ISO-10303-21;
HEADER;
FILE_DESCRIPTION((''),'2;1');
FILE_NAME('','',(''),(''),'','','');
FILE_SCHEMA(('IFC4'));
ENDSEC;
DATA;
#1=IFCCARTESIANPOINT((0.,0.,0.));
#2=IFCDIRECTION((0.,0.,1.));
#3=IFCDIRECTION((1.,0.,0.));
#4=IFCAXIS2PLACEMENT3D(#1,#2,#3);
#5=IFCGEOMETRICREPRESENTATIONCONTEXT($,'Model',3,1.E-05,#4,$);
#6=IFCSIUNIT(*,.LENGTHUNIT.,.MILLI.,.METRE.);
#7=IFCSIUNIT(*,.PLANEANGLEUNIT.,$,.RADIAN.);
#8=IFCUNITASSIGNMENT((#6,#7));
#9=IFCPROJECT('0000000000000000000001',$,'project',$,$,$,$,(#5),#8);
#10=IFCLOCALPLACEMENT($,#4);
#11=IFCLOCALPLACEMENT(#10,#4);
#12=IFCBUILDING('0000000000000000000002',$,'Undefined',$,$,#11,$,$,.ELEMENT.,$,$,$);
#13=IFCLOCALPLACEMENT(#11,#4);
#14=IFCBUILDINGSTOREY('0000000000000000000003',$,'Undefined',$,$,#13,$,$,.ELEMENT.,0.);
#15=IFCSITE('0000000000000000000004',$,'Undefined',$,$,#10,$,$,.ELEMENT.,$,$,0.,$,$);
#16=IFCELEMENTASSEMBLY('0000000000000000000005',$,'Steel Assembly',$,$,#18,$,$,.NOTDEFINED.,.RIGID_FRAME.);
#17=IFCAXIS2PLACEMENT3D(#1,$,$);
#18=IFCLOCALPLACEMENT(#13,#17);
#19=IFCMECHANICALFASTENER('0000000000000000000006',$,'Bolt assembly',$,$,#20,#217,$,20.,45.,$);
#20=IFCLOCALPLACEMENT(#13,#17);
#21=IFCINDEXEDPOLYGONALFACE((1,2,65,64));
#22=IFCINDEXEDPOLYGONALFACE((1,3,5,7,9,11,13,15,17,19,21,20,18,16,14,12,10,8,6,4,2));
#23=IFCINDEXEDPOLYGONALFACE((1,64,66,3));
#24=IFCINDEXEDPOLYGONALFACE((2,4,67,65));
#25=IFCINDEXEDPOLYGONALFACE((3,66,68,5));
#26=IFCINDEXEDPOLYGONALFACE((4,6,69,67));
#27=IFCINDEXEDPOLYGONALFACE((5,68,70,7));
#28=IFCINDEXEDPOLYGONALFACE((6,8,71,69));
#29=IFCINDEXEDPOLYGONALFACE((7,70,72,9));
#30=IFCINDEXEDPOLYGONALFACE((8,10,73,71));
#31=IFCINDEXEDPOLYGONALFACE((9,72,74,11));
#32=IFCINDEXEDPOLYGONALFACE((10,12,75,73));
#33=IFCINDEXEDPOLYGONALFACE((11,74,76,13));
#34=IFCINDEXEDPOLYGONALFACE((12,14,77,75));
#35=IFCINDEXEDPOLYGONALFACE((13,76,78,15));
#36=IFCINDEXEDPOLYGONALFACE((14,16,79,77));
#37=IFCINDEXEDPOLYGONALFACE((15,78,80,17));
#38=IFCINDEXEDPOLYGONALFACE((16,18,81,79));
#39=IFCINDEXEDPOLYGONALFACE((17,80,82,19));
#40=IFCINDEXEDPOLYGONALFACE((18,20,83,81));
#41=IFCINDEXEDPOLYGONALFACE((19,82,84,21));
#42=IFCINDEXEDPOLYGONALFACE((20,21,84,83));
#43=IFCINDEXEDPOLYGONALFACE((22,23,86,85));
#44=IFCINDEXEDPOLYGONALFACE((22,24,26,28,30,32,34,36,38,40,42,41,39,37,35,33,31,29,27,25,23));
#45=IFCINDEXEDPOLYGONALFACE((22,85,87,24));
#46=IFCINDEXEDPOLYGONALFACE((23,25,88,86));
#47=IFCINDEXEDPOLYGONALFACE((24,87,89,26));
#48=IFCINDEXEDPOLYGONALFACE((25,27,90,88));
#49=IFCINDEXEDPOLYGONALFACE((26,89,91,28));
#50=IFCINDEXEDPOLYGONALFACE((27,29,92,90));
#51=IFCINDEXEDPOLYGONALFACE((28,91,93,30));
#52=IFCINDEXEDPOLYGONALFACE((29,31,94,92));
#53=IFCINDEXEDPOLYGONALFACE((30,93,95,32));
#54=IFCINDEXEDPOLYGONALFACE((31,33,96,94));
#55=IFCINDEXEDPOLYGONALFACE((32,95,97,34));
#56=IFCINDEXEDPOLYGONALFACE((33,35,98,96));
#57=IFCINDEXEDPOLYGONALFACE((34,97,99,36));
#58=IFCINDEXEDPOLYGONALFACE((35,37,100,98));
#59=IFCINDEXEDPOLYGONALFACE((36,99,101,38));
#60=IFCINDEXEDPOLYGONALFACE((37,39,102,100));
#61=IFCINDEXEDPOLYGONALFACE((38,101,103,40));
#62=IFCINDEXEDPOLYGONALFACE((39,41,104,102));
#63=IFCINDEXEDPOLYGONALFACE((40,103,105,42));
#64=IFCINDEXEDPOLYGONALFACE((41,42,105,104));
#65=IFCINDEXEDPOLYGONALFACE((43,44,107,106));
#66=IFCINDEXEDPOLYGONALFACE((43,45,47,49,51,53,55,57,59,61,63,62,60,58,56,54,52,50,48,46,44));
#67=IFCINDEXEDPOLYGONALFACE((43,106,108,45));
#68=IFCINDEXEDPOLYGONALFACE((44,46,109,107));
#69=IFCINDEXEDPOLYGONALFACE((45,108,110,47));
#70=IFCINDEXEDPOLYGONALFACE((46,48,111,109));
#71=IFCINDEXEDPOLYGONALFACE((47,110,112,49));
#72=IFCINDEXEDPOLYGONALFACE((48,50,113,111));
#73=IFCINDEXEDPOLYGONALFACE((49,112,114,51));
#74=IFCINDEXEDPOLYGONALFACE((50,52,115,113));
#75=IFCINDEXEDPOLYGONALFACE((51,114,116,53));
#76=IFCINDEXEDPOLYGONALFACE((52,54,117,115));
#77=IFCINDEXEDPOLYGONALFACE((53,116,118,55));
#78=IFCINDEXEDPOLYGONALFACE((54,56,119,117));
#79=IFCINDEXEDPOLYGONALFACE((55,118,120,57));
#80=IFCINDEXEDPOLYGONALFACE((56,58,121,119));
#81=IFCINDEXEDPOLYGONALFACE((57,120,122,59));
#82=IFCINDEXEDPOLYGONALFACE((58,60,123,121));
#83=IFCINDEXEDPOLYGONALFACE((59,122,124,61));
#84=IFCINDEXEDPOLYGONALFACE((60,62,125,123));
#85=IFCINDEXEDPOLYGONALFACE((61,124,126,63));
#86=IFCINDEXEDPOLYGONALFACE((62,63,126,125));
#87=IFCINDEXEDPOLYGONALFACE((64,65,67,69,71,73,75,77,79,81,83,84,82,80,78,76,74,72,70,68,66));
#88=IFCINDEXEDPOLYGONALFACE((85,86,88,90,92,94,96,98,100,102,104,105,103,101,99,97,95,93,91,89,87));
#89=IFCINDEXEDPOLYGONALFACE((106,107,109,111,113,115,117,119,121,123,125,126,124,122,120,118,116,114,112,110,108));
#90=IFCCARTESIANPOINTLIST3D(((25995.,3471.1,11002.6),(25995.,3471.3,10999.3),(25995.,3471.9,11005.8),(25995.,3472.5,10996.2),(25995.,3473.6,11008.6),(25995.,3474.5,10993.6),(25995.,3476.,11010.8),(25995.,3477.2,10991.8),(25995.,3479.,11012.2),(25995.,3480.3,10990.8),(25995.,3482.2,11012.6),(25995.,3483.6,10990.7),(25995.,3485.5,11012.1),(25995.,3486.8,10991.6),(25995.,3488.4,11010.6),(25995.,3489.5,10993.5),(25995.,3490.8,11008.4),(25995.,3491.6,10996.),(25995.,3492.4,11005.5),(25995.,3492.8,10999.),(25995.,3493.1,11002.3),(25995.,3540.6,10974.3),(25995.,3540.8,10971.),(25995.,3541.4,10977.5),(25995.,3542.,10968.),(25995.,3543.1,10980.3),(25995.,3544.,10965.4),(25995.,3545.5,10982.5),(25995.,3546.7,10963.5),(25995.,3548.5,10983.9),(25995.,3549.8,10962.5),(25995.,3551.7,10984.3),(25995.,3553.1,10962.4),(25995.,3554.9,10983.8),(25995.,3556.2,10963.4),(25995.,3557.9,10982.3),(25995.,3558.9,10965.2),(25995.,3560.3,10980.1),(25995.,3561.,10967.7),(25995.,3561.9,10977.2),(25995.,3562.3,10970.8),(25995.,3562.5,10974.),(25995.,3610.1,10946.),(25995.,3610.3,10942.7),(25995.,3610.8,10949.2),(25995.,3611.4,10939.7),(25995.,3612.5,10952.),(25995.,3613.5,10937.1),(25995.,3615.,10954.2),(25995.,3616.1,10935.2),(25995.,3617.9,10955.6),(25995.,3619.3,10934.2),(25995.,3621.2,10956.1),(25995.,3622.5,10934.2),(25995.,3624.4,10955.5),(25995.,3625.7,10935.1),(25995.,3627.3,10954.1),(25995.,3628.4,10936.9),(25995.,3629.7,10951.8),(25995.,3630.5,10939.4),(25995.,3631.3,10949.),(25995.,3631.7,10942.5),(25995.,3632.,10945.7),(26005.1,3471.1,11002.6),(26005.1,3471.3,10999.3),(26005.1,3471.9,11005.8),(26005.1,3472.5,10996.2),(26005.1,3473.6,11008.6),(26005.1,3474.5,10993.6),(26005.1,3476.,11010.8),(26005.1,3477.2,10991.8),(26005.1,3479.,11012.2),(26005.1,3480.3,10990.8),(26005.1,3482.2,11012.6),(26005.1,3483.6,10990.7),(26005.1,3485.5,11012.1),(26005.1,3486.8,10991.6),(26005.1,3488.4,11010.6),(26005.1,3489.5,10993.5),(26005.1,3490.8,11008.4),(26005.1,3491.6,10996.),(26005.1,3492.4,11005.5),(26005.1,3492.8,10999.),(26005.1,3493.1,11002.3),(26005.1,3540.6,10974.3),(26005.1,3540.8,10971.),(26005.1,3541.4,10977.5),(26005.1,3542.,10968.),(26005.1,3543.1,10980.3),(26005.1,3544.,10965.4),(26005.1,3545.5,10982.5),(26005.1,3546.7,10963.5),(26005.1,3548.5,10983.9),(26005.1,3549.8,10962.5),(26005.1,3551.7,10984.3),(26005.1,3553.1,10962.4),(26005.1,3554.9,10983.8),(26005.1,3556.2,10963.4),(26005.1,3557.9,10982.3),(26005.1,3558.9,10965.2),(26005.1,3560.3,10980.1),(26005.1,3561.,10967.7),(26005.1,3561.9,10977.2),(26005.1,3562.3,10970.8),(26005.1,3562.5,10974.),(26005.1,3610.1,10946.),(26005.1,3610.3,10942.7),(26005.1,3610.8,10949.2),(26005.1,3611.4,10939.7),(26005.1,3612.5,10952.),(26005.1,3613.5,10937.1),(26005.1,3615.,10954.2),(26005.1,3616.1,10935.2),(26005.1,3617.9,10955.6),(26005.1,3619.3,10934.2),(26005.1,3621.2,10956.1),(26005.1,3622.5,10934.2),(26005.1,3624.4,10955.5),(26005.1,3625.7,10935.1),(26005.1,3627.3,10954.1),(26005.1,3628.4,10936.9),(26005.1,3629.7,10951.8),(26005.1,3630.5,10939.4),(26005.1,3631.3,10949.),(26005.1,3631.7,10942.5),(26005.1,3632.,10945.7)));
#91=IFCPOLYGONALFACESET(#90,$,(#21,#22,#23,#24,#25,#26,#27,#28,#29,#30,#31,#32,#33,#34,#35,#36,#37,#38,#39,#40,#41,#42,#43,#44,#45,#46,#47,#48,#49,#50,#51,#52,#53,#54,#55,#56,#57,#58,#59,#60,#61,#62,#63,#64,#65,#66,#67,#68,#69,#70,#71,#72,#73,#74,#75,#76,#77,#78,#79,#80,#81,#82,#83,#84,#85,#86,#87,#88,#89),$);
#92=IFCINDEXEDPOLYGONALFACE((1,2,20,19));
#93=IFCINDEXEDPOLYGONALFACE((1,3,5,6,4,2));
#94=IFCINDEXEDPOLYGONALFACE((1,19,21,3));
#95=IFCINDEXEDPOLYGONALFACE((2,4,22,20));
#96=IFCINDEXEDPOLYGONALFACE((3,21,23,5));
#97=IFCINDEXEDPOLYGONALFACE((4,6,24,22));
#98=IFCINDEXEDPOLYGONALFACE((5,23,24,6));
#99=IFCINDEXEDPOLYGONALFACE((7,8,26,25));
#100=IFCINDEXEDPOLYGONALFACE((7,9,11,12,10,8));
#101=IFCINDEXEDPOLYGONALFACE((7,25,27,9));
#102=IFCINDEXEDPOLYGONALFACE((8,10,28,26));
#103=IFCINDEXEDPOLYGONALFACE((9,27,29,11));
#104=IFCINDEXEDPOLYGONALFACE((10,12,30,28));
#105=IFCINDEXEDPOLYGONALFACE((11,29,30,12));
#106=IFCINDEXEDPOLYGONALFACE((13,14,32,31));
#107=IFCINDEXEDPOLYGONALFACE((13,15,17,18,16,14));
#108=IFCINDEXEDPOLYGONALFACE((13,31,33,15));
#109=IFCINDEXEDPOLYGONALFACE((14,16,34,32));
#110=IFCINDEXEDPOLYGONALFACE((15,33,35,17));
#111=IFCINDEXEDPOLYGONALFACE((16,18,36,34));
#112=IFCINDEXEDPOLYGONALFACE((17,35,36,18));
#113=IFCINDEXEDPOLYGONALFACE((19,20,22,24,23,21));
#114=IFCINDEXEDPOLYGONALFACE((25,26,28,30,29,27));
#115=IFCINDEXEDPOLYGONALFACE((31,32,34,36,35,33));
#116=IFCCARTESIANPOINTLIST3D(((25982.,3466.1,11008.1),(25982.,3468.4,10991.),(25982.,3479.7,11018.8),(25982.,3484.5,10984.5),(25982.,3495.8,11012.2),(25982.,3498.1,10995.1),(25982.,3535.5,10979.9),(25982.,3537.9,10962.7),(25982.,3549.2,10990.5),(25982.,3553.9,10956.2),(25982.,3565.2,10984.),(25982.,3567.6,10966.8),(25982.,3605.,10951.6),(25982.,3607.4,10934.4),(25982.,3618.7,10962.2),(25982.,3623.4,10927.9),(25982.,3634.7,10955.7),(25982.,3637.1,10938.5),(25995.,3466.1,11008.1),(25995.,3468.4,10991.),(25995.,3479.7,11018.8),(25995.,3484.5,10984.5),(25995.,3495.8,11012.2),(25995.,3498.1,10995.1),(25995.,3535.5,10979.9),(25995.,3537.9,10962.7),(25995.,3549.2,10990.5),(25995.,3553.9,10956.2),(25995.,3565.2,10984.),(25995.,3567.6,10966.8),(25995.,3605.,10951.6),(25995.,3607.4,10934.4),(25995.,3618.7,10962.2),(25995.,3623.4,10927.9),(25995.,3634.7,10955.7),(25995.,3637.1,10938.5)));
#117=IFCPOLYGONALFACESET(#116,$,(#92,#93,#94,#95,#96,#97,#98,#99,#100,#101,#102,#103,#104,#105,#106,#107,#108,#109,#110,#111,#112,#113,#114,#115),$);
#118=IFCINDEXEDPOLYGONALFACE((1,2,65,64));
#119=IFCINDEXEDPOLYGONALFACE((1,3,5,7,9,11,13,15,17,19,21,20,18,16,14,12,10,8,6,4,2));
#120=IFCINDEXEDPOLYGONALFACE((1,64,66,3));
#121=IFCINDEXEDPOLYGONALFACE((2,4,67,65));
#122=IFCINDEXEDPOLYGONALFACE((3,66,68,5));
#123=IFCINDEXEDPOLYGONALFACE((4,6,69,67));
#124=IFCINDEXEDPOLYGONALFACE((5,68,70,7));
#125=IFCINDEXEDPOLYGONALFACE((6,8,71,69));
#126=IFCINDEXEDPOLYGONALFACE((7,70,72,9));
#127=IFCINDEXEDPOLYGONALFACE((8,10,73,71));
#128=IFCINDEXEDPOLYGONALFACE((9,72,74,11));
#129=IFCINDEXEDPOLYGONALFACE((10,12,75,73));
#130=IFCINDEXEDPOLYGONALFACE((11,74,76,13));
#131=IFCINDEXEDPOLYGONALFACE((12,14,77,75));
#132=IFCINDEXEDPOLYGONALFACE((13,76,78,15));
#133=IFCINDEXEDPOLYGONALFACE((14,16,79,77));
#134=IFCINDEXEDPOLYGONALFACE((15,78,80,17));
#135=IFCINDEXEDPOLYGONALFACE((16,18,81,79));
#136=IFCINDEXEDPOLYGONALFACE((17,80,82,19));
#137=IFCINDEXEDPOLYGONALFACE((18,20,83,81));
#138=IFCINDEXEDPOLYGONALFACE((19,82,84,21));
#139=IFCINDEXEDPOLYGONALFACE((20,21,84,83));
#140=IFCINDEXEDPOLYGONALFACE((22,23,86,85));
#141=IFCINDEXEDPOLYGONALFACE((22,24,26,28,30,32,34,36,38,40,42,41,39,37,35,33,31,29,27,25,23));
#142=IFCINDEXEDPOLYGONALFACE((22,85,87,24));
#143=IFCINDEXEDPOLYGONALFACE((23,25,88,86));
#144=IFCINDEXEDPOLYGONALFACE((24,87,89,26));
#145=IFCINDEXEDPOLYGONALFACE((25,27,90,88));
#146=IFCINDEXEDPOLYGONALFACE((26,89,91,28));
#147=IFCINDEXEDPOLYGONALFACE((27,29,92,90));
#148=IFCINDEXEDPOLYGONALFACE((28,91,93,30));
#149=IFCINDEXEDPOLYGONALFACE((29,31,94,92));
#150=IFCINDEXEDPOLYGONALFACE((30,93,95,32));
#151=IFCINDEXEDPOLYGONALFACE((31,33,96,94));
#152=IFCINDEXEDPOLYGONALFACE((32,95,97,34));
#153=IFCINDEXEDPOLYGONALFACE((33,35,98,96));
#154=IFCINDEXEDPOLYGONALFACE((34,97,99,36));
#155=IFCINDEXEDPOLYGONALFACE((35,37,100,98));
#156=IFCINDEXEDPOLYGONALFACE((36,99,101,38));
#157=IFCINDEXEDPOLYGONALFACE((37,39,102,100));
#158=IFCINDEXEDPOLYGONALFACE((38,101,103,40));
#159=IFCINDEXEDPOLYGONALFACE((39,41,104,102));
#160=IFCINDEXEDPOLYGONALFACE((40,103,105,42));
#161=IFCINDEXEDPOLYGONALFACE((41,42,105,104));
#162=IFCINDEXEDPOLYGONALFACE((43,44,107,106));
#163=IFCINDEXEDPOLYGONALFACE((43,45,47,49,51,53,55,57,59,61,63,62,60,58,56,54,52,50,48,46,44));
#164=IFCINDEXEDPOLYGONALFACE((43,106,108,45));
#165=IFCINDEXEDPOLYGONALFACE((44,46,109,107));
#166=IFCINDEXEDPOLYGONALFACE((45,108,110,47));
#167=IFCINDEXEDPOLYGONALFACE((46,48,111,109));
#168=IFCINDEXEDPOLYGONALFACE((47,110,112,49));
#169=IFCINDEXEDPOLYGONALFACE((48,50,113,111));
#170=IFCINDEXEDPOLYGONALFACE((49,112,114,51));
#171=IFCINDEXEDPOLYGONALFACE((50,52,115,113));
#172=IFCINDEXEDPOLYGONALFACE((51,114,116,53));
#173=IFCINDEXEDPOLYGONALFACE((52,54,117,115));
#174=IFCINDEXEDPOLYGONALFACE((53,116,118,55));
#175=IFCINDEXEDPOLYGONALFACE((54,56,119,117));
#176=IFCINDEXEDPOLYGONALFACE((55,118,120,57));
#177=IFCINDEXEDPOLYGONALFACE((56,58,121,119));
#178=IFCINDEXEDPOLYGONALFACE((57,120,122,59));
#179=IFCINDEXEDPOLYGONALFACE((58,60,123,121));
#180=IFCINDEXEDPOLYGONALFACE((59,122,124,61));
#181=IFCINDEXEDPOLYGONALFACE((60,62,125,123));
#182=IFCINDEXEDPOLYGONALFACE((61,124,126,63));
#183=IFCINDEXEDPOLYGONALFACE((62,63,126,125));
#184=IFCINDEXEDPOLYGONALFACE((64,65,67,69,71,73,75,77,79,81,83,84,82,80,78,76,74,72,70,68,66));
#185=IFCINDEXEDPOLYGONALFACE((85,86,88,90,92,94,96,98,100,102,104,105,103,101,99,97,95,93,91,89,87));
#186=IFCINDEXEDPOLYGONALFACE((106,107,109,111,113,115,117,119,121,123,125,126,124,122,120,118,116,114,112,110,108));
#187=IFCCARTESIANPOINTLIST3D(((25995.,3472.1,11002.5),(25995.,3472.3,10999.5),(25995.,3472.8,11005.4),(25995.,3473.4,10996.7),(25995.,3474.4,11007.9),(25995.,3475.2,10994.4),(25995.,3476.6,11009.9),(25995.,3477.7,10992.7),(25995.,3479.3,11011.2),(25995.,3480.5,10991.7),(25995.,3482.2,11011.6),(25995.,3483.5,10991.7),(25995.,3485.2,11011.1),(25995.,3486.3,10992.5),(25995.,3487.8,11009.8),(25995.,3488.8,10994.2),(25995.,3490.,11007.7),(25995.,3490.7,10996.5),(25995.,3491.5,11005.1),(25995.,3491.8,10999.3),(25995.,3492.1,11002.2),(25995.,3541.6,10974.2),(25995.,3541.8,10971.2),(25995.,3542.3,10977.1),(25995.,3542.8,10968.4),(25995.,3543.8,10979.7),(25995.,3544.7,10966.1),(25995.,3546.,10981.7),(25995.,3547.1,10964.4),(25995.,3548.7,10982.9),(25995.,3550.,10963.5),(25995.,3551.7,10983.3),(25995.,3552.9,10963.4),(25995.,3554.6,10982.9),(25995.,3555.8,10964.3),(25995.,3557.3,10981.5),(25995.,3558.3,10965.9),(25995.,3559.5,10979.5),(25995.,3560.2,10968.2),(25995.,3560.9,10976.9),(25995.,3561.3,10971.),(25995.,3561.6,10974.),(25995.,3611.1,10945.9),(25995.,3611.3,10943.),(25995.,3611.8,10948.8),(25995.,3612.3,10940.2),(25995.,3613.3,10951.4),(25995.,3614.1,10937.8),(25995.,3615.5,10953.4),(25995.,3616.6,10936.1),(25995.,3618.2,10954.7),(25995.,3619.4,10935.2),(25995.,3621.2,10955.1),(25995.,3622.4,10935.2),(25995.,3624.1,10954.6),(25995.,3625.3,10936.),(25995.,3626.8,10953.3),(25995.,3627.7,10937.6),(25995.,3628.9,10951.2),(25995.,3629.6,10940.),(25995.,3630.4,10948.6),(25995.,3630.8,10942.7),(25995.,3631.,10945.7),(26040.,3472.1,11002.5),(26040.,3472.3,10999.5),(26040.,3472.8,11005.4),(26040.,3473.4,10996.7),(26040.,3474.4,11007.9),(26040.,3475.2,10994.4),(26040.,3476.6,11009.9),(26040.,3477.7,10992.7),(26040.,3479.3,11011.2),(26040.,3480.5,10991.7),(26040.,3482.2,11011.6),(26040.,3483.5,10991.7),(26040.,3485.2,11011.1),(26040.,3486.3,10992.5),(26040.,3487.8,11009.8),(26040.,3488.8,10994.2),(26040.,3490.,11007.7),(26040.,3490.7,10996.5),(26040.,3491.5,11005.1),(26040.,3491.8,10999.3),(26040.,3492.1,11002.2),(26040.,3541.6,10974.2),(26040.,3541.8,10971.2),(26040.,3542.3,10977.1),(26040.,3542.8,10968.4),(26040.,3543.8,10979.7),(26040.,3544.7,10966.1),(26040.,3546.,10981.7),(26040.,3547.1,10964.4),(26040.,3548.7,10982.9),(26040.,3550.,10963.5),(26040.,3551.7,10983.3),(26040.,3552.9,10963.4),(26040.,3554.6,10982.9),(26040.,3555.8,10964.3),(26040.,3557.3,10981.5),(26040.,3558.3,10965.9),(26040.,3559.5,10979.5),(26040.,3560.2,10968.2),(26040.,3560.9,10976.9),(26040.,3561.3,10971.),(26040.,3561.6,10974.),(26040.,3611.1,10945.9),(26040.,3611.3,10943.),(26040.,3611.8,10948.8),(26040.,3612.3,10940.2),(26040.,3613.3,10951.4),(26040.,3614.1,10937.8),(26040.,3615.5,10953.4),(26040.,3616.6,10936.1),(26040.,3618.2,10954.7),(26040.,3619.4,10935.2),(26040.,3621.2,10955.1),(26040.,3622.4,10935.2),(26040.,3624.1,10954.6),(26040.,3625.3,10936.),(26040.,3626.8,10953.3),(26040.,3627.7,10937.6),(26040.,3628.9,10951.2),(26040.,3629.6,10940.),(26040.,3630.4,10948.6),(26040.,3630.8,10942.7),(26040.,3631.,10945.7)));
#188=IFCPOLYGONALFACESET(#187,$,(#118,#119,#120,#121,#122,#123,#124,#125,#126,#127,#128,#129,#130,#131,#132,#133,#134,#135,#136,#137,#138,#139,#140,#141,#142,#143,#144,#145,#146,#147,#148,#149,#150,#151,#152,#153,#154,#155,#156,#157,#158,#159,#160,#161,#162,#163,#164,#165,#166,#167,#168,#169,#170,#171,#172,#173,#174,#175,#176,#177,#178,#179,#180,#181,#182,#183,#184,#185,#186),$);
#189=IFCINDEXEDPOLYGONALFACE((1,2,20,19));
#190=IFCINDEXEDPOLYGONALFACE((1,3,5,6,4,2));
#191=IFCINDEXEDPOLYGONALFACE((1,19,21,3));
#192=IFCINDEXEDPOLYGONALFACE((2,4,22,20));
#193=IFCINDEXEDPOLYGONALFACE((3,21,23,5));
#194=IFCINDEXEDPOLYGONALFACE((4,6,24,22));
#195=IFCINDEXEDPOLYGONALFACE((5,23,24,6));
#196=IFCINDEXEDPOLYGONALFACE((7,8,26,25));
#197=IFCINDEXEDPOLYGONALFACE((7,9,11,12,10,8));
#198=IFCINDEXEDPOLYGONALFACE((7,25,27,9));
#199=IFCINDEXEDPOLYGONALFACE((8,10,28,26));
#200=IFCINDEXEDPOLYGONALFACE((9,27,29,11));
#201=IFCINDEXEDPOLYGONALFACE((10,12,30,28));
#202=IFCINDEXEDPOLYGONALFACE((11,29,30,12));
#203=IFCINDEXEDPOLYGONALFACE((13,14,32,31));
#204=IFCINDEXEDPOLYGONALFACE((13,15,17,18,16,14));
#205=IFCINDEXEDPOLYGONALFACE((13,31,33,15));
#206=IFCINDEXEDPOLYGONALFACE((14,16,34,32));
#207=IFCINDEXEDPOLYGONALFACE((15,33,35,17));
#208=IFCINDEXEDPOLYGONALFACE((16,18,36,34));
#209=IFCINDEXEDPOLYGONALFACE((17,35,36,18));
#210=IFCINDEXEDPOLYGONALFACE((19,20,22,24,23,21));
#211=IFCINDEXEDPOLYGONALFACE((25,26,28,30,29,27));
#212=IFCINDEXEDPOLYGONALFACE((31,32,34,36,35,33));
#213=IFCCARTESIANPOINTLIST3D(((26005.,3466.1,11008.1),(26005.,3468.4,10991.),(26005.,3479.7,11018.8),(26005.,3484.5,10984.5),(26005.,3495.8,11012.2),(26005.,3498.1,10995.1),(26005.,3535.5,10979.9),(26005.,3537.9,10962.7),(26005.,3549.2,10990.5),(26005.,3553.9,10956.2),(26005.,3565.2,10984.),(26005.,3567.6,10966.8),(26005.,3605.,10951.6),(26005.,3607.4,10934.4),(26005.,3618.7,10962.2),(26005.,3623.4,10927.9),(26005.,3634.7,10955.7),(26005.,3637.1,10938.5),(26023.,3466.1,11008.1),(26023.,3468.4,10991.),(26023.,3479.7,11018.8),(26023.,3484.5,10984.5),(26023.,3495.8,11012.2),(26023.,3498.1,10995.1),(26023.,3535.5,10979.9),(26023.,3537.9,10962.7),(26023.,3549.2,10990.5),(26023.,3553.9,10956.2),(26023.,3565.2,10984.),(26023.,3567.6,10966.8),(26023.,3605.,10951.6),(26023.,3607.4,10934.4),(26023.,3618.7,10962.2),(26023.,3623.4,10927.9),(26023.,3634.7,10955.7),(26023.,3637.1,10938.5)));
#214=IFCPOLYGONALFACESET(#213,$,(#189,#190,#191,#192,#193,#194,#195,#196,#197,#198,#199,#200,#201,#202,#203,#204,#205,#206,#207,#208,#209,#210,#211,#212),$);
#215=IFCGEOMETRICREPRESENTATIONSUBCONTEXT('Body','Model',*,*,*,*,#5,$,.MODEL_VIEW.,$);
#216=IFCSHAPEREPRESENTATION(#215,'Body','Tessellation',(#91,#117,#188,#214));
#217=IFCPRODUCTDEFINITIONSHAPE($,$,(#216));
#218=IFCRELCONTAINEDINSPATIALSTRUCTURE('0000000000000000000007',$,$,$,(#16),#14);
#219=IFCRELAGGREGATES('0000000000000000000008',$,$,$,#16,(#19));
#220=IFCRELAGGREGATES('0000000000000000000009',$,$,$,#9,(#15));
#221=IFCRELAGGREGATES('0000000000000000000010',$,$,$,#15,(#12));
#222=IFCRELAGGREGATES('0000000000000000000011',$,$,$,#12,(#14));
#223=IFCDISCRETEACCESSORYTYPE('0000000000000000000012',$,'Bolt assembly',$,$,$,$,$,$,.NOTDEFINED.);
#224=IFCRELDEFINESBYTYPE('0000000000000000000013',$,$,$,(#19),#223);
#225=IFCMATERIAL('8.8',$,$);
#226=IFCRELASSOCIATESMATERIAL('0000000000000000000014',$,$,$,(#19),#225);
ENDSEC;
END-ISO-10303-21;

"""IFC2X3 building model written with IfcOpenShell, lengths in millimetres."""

from ifc_helpers import new_model, si_unit, frame, origin_with_axes, origin_2d_with_axis, place, context, subcontext, project, spatial, polyline, circle, outline, extrude, source, transform, mapped, material, type_object, element, aggregate, save


model = new_model("IFC2X3")

# Units and contexts
model_context = context("Model", 3, precision=1e-05, world=origin_with_axes())
body_context = subcontext(model_context, "Body", "Model", "MODEL_VIEW")
ifc_project = project(units=[si_unit("LENGTHUNIT", "METRE", prefix="MILLI"), si_unit("PLANEANGLEUNIT", "RADIAN")], contexts=[model_context])

# Site, building, storey
site_placement = place(None, origin_with_axes())
site = spatial("IfcSite", under=ifc_project, at=site_placement, Name="Undefined", CompositionType="ELEMENT", RefElevation=0.0)
building_placement = place(site_placement, origin_with_axes())
building = spatial("IfcBuilding", under=site, at=building_placement, Name="Undefined", CompositionType="ELEMENT")
storey_placement = place(building_placement, origin_with_axes())
storey = spatial("IfcBuildingStorey", under=building, at=storey_placement, Name="Undefined", CompositionType="ELEMENT", Elevation=0.0)

# Shared definitions
ifc_material_1 = material(Name="8.8")
discrete_accessory_type_1 = type_object("IfcDiscreteAccessoryType", Name="Bolt assembly")

# Element assembly
assembly_1_placement = place(storey_placement, origin_with_axes())
assembly_1 = element("IfcElementAssembly", 1, at=assembly_1_placement, inside=storey, Name="Steel Assembly", AssemblyPlace="NOTDEFINED", PredefinedType="RIGID_FRAME")

# Mechanical fastener
shared_shape_1 = source(origin_with_axes(), body_context, "Body", "SweptSolid", [
    extrude(circle(Radius=11.0, at=origin_2d_with_axis()), frame((0.0, -5.0, 0.0), z_axis=(0.0, 1.0, 0.0), x_axis=(1.0, 0.0, 0.0)), (0.0, 0.0, 1.0), 10.1),
    extrude(outline(polyline([(17.3, 0.0), (8.7, 15.0), (-8.7, 15.0), (-17.3, 0.0), (-8.7, -15.0), (8.7, -15.0), (17.3, 0.0)])), frame((0.0, -18.0, 0.0), z_axis=(0.0, 1.0, 0.0), x_axis=(1.0, 0.0, 0.0)), (0.0, 0.0, 1.0), 13.0),
    extrude(circle(Radius=10.0, at=origin_2d_with_axis()), frame((0.0, -5.0, 0.0), z_axis=(0.0, 1.0, 0.0), x_axis=(1.0, 0.0, 0.0)), (0.0, 0.0, 1.0), 45.0),
    extrude(outline(polyline([(17.3, 0.0), (8.7, 15.0), (-8.7, 15.0), (-17.3, 0.0), (-8.7, -15.0), (8.7, -15.0), (17.3, 0.0)])), frame((0.0, 5.0, 0.0), z_axis=(0.0, 1.0, 0.0), x_axis=(1.0, 0.0, 0.0)), (0.0, 0.0, 1.0), 18.0),
])
mechanical_fastener_1_placement = place(assembly_1_placement, frame((26000.0, 3621.0, 10945.1), z_axis=(0.0, 0.376988, 0.926218), x_axis=(0.0, -0.926218, 0.376988)))
mechanical_fastener_1 = element("IfcMechanicalFastener", 2, at=mechanical_fastener_1_placement, type_object=discrete_accessory_type_1, material=ifc_material_1, Name="Bolt assembly", NominalDiameter=20.0, NominalLength=45.0, context=body_context, shape_type="MappedRepresentation", body=[
    mapped(shared_shape_1, transform((0.0, 0.0, 0.0))),
    mapped(shared_shape_1, transform((75.0, 0.0, 0.0))),
    mapped(shared_shape_1, transform((150.0, 0.0, 0.0))),
])
aggregate(assembly_1, [mechanical_fastener_1])

save(model, "model.ifc")
